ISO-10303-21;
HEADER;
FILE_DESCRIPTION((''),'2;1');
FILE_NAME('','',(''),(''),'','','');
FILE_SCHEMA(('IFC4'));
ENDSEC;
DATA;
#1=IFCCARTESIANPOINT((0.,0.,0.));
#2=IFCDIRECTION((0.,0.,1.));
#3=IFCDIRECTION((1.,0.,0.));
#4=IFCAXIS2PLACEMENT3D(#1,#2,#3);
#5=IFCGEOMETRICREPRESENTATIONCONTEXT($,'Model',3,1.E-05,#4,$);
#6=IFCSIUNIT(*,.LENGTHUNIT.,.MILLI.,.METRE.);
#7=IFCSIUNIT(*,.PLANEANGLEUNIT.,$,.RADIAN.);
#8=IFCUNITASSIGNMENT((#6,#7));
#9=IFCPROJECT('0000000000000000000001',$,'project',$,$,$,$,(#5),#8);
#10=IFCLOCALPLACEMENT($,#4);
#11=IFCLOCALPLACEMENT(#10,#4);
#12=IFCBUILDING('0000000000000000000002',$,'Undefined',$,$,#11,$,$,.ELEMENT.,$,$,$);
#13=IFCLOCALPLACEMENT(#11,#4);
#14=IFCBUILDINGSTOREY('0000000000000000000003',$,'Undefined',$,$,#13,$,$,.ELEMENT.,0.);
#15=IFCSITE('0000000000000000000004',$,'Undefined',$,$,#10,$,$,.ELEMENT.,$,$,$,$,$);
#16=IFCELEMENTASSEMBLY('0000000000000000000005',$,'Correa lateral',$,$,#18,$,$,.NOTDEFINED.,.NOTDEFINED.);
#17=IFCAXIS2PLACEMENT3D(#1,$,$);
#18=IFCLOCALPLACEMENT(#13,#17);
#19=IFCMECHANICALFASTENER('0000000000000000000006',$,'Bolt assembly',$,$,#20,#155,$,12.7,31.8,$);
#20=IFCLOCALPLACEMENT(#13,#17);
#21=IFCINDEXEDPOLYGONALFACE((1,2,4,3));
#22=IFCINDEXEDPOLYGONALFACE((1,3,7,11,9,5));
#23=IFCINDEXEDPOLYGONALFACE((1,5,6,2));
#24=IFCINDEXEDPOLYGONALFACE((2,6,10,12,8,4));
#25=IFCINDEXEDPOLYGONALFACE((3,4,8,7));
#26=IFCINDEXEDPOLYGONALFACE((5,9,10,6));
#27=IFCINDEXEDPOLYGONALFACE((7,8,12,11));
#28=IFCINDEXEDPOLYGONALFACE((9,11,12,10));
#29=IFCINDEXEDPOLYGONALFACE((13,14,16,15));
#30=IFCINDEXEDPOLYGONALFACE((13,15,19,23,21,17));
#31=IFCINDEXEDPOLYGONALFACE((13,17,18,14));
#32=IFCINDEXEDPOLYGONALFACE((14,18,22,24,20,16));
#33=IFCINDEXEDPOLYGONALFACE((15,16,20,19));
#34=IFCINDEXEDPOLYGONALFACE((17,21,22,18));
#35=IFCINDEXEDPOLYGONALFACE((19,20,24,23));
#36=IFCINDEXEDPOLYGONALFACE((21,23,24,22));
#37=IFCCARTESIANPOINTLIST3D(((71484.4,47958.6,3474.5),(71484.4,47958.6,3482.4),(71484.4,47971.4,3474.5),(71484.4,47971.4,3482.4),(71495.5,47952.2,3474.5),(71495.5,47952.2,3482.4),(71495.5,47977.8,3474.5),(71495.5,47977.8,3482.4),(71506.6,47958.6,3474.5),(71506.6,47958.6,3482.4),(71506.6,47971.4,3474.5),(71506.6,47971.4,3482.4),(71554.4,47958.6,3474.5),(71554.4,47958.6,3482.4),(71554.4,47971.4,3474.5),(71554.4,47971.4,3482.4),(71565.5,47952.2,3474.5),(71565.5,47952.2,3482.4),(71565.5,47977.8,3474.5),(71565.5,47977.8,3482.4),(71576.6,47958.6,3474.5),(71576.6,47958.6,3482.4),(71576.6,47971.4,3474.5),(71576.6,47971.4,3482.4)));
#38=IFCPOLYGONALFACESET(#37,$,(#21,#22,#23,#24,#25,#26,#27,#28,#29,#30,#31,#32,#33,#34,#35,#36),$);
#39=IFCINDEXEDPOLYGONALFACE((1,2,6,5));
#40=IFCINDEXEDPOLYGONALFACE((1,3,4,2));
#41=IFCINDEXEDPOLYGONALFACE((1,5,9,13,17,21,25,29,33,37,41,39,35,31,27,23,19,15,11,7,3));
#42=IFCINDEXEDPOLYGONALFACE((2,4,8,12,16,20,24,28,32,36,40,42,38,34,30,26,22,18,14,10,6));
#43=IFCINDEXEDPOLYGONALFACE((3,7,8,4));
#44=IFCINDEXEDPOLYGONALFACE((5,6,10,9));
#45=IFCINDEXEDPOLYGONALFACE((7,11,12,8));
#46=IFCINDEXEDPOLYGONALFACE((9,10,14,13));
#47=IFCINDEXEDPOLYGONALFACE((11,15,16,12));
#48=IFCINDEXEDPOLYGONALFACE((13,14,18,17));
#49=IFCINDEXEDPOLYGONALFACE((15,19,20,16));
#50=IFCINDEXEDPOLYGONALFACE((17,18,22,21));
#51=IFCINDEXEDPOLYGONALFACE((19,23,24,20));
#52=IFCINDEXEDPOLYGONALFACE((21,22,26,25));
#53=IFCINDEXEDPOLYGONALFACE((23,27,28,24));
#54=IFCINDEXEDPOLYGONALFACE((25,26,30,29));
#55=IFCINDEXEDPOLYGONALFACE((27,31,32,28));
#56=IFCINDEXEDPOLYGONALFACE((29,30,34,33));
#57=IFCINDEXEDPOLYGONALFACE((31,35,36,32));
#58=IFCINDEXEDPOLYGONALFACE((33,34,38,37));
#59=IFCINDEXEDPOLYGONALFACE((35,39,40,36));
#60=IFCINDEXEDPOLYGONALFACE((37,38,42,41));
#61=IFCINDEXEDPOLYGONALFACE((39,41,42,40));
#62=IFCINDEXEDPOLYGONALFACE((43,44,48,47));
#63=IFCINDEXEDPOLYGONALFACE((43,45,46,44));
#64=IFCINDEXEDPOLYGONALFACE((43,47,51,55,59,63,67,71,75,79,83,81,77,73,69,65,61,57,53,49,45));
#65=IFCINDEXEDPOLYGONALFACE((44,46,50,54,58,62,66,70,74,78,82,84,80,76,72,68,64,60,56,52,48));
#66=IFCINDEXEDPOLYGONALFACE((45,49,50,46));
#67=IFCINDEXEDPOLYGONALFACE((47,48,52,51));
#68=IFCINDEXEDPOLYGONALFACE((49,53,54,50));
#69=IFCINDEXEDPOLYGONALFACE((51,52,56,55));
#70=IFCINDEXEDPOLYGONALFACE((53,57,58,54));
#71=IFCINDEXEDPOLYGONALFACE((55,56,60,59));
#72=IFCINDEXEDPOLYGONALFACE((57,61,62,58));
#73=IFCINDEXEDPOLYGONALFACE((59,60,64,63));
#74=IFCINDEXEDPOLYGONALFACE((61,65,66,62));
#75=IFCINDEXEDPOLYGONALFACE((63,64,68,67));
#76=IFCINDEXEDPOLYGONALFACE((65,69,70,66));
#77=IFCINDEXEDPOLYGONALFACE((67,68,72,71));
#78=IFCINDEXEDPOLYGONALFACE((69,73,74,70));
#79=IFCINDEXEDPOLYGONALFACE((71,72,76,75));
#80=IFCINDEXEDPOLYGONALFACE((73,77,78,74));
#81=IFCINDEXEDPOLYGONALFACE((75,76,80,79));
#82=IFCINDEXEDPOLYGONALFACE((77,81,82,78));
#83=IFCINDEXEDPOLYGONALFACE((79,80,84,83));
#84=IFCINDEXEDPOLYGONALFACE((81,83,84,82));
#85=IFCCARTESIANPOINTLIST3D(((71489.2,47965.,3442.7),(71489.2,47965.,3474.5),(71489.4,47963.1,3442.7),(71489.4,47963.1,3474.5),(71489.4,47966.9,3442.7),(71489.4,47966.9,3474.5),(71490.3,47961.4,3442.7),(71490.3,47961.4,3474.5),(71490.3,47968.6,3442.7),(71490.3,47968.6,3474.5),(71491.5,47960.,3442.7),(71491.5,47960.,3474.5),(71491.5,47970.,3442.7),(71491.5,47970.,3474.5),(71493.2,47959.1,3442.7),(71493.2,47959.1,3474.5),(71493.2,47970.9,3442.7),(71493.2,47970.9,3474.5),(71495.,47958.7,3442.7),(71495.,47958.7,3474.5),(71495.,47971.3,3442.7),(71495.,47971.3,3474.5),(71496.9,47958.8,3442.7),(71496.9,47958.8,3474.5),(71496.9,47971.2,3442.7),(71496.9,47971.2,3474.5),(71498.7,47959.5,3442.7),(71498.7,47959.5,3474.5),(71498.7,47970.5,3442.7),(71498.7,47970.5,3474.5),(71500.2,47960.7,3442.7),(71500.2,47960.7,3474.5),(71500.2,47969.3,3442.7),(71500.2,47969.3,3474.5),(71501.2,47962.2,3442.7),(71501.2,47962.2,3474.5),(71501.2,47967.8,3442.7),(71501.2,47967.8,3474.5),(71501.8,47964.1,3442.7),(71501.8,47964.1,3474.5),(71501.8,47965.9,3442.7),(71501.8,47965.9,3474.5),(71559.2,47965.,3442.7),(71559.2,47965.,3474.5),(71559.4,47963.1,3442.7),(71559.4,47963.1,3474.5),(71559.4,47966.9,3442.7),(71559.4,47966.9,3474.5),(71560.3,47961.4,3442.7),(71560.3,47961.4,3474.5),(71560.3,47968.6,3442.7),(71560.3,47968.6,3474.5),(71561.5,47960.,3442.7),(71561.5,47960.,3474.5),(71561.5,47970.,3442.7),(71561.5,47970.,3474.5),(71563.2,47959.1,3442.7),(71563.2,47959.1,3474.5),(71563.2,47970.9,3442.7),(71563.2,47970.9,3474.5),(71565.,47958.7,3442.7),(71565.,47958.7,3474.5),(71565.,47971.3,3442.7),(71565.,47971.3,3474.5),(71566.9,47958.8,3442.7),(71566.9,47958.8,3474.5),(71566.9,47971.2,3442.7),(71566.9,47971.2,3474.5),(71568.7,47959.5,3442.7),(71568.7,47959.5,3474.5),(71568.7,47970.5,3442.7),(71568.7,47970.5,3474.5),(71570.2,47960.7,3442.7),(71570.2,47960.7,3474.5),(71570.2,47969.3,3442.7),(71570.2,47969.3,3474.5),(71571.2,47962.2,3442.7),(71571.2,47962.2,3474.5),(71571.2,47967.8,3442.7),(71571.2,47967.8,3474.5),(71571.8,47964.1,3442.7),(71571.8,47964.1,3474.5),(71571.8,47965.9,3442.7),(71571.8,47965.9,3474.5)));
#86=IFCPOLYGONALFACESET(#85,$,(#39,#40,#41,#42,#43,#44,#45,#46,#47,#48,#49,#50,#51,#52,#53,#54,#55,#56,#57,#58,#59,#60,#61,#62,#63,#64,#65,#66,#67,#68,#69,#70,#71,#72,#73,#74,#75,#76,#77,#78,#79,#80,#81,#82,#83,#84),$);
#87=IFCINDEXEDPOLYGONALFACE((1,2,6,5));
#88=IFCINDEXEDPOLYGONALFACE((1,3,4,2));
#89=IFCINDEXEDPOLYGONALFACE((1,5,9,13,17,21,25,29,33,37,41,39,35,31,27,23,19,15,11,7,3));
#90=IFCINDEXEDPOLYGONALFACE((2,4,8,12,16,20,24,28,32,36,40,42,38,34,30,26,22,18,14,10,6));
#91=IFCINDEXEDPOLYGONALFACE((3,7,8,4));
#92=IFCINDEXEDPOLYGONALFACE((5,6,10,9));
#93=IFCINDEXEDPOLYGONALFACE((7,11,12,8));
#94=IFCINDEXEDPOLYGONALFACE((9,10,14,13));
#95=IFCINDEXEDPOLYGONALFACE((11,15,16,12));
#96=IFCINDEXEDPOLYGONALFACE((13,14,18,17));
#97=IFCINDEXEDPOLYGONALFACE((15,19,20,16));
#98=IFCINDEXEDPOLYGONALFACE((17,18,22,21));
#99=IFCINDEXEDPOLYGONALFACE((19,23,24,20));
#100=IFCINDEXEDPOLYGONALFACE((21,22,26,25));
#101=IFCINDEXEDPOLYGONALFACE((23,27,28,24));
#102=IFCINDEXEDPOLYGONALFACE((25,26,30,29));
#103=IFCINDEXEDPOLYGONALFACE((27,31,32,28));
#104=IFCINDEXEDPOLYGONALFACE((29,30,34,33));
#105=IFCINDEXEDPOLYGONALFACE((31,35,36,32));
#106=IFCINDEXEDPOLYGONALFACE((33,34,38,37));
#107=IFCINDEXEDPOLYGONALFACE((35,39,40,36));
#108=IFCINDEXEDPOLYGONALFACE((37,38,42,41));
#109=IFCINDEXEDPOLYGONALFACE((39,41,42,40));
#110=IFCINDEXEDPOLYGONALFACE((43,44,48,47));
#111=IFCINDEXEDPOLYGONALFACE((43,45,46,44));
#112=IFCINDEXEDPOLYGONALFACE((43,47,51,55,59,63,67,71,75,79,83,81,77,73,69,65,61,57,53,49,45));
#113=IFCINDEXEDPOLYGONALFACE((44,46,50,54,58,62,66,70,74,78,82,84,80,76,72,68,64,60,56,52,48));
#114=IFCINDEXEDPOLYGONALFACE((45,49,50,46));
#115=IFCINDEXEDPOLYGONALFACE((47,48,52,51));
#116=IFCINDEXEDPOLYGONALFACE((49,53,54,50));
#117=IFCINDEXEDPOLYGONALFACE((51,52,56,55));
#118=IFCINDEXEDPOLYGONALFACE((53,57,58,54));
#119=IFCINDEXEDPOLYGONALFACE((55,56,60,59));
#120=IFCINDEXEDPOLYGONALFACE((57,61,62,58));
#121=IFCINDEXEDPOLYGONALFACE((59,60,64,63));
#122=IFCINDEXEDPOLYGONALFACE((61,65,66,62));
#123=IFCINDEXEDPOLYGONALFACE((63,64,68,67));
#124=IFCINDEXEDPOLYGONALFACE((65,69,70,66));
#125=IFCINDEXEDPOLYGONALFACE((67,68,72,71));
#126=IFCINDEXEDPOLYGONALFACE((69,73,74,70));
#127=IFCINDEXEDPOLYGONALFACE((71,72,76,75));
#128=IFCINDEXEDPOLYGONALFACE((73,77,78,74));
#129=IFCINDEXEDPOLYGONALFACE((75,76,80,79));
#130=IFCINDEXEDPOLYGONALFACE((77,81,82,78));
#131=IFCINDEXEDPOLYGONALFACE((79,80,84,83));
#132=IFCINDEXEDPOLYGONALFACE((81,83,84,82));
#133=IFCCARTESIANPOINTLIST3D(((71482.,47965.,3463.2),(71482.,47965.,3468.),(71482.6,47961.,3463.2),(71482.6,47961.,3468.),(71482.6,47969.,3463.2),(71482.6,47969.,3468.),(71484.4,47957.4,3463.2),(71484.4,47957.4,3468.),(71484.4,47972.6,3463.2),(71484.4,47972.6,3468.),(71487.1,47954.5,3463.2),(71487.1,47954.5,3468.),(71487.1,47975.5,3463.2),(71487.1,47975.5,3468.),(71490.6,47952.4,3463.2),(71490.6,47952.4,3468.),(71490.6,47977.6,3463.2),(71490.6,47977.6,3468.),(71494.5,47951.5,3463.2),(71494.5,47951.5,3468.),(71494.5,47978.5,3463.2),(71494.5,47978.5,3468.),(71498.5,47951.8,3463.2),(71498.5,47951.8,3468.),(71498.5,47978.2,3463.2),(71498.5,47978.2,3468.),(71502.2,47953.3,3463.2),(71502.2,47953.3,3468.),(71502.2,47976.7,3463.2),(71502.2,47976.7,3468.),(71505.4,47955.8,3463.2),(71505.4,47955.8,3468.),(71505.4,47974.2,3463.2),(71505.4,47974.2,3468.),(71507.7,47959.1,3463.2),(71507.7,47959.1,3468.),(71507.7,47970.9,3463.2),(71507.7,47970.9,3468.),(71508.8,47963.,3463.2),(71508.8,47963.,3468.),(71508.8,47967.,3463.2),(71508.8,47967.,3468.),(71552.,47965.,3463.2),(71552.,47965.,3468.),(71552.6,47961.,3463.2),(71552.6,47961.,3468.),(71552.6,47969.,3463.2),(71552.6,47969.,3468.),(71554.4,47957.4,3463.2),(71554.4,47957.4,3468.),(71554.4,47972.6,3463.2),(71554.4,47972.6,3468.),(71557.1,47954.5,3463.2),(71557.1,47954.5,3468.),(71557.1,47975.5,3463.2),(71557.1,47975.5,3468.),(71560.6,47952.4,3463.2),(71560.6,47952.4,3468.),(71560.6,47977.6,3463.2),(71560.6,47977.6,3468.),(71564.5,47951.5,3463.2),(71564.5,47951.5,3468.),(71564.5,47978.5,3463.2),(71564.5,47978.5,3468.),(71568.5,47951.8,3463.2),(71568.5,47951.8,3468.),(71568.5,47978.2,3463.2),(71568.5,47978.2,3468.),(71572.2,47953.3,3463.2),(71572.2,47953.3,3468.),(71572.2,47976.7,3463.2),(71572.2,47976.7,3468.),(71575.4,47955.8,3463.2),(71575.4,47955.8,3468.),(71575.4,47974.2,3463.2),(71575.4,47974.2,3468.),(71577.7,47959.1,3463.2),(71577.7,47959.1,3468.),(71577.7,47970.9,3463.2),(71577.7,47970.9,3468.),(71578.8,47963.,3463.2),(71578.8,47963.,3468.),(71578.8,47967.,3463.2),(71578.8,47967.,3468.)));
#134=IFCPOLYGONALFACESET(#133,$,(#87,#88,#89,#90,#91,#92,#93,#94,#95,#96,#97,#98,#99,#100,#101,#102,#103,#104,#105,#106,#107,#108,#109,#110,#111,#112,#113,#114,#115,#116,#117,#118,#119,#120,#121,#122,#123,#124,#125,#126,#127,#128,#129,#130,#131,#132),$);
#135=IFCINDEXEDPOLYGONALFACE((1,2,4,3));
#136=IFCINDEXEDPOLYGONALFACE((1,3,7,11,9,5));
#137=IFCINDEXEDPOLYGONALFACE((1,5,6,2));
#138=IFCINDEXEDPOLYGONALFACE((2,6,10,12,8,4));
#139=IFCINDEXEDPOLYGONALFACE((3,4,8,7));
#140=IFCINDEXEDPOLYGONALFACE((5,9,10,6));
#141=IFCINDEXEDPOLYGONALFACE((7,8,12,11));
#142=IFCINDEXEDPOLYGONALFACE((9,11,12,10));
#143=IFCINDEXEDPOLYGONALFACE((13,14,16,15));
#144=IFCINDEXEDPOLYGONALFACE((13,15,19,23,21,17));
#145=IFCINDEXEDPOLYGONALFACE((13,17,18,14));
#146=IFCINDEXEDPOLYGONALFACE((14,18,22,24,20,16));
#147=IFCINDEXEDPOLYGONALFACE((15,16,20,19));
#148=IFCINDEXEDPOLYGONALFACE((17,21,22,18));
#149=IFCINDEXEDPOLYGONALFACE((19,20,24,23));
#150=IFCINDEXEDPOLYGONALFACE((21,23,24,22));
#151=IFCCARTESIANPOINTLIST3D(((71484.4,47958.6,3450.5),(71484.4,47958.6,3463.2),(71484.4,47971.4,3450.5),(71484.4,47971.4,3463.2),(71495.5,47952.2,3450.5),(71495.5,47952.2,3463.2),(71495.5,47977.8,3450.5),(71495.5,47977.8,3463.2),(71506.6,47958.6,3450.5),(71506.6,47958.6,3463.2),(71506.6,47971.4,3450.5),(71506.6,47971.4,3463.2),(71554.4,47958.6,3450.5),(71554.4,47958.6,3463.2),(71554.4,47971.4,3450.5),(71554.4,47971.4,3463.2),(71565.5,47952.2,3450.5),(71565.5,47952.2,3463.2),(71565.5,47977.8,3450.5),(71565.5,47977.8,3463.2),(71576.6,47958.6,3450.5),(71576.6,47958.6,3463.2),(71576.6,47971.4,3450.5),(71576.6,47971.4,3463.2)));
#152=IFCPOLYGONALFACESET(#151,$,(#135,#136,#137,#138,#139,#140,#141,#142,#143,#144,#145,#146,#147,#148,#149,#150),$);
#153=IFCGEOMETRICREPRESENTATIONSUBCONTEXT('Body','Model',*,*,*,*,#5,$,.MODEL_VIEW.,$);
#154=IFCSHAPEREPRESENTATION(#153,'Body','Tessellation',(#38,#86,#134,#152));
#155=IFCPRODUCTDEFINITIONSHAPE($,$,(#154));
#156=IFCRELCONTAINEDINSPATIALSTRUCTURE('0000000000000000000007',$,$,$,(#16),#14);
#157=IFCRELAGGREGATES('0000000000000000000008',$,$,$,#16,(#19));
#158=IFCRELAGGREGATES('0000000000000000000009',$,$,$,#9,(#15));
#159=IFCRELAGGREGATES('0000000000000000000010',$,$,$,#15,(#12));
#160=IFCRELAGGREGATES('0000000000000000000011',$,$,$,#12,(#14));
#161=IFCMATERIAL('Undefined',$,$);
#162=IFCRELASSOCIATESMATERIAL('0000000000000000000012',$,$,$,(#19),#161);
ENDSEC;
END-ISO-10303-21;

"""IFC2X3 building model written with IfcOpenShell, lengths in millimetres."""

from ifc_helpers import new_model, si_unit, frame, origin_with_axes, origin_2d_with_axis, place, context, subcontext, project, spatial, polyline, circle, outline, extrude, source, transform, mapped, material, element, aggregate, save


model = new_model("IFC2X3")

# Units and contexts
model_context = context("Model", 3, precision=1e-05, world=origin_with_axes())
body_context = subcontext(model_context, "Body", "Model", "MODEL_VIEW")
ifc_project = project(units=[si_unit("LENGTHUNIT", "METRE", prefix="MILLI"), si_unit("PLANEANGLEUNIT", "RADIAN")], contexts=[model_context])

# Site, building, storey
site_placement = place(None, origin_with_axes())
site = spatial("IfcSite", under=ifc_project, at=site_placement, Name="Undefined", CompositionType="ELEMENT")
building_placement = place(site_placement, origin_with_axes())
building = spatial("IfcBuilding", under=site, at=building_placement, Name="Undefined", CompositionType="ELEMENT")
storey_placement = place(building_placement, origin_with_axes())
storey = spatial("IfcBuildingStorey", under=building, at=storey_placement, Name="Undefined", CompositionType="ELEMENT", Elevation=0.0)

# Element assembly
assembly_1_placement = place(storey_placement, origin_with_axes())
assembly_1 = element("IfcElementAssembly", 1, at=assembly_1_placement, inside=storey, Name="Correa lateral", AssemblyPlace="NOTDEFINED", PredefinedType="NOTDEFINED")

# Mechanical fastener
ifc_material_1 = material(Name="Undefined")
shared_shape_1 = source(origin_with_axes(), body_context, "Body", "SweptSolid", [
    extrude(outline(polyline([(11.1, -6.4), (11.1, 6.4), (0.0, 12.8), (-11.1, 6.4), (-11.1, -6.4), (0.0, -12.8), (11.1, -6.4)])), frame((0.0, -12.4, 0.0), z_axis=(0.0, 1.0, 0.0), x_axis=(1.0, 0.0, 0.0)), (0.0, 0.0, 1.0), 7.9),
    extrude(circle(Radius=6.3, at=origin_2d_with_axis()), frame((0.0, -4.5, 0.0), z_axis=(0.0, 1.0, 0.0), x_axis=(1.0, 0.0, 0.0)), (0.0, 0.0, 1.0), 31.8),
    extrude(circle(Radius=13.5, at=origin_2d_with_axis()), frame((0.0, 2.0, 0.0), z_axis=(0.0, 1.0, 0.0), x_axis=(1.0, 0.0, 0.0)), (0.0, 0.0, 1.0), 4.8),
    extrude(outline(polyline([(11.1, -6.4), (11.1, 6.4), (0.0, 12.8), (-11.1, 6.4), (-11.1, -6.4), (0.0, -12.8), (11.1, -6.4)])), frame((0.0, 6.8, 0.0), z_axis=(0.0, 1.0, 0.0), x_axis=(1.0, 0.0, 0.0)), (0.0, 0.0, 1.0), 12.7),
])
mechanical_fastener_1_placement = place(assembly_1_placement, frame((71565.5, 47965.0, 3470.0), z_axis=(0.0, -1.0, 0.0), x_axis=(-1.0, 0.0, 0.0)))
mechanical_fastener_1 = element("IfcMechanicalFastener", 2, at=mechanical_fastener_1_placement, material=ifc_material_1, Name="Bolt assembly", NominalDiameter=12.7, NominalLength=31.8, context=body_context, shape_type="MappedRepresentation", body=[
    mapped(shared_shape_1, transform((0.0, 0.0, 0.0))),
    mapped(shared_shape_1, transform((70.0, 0.0, 0.0))),
])
aggregate(assembly_1, [mechanical_fastener_1])

save(model, "model.ifc")
